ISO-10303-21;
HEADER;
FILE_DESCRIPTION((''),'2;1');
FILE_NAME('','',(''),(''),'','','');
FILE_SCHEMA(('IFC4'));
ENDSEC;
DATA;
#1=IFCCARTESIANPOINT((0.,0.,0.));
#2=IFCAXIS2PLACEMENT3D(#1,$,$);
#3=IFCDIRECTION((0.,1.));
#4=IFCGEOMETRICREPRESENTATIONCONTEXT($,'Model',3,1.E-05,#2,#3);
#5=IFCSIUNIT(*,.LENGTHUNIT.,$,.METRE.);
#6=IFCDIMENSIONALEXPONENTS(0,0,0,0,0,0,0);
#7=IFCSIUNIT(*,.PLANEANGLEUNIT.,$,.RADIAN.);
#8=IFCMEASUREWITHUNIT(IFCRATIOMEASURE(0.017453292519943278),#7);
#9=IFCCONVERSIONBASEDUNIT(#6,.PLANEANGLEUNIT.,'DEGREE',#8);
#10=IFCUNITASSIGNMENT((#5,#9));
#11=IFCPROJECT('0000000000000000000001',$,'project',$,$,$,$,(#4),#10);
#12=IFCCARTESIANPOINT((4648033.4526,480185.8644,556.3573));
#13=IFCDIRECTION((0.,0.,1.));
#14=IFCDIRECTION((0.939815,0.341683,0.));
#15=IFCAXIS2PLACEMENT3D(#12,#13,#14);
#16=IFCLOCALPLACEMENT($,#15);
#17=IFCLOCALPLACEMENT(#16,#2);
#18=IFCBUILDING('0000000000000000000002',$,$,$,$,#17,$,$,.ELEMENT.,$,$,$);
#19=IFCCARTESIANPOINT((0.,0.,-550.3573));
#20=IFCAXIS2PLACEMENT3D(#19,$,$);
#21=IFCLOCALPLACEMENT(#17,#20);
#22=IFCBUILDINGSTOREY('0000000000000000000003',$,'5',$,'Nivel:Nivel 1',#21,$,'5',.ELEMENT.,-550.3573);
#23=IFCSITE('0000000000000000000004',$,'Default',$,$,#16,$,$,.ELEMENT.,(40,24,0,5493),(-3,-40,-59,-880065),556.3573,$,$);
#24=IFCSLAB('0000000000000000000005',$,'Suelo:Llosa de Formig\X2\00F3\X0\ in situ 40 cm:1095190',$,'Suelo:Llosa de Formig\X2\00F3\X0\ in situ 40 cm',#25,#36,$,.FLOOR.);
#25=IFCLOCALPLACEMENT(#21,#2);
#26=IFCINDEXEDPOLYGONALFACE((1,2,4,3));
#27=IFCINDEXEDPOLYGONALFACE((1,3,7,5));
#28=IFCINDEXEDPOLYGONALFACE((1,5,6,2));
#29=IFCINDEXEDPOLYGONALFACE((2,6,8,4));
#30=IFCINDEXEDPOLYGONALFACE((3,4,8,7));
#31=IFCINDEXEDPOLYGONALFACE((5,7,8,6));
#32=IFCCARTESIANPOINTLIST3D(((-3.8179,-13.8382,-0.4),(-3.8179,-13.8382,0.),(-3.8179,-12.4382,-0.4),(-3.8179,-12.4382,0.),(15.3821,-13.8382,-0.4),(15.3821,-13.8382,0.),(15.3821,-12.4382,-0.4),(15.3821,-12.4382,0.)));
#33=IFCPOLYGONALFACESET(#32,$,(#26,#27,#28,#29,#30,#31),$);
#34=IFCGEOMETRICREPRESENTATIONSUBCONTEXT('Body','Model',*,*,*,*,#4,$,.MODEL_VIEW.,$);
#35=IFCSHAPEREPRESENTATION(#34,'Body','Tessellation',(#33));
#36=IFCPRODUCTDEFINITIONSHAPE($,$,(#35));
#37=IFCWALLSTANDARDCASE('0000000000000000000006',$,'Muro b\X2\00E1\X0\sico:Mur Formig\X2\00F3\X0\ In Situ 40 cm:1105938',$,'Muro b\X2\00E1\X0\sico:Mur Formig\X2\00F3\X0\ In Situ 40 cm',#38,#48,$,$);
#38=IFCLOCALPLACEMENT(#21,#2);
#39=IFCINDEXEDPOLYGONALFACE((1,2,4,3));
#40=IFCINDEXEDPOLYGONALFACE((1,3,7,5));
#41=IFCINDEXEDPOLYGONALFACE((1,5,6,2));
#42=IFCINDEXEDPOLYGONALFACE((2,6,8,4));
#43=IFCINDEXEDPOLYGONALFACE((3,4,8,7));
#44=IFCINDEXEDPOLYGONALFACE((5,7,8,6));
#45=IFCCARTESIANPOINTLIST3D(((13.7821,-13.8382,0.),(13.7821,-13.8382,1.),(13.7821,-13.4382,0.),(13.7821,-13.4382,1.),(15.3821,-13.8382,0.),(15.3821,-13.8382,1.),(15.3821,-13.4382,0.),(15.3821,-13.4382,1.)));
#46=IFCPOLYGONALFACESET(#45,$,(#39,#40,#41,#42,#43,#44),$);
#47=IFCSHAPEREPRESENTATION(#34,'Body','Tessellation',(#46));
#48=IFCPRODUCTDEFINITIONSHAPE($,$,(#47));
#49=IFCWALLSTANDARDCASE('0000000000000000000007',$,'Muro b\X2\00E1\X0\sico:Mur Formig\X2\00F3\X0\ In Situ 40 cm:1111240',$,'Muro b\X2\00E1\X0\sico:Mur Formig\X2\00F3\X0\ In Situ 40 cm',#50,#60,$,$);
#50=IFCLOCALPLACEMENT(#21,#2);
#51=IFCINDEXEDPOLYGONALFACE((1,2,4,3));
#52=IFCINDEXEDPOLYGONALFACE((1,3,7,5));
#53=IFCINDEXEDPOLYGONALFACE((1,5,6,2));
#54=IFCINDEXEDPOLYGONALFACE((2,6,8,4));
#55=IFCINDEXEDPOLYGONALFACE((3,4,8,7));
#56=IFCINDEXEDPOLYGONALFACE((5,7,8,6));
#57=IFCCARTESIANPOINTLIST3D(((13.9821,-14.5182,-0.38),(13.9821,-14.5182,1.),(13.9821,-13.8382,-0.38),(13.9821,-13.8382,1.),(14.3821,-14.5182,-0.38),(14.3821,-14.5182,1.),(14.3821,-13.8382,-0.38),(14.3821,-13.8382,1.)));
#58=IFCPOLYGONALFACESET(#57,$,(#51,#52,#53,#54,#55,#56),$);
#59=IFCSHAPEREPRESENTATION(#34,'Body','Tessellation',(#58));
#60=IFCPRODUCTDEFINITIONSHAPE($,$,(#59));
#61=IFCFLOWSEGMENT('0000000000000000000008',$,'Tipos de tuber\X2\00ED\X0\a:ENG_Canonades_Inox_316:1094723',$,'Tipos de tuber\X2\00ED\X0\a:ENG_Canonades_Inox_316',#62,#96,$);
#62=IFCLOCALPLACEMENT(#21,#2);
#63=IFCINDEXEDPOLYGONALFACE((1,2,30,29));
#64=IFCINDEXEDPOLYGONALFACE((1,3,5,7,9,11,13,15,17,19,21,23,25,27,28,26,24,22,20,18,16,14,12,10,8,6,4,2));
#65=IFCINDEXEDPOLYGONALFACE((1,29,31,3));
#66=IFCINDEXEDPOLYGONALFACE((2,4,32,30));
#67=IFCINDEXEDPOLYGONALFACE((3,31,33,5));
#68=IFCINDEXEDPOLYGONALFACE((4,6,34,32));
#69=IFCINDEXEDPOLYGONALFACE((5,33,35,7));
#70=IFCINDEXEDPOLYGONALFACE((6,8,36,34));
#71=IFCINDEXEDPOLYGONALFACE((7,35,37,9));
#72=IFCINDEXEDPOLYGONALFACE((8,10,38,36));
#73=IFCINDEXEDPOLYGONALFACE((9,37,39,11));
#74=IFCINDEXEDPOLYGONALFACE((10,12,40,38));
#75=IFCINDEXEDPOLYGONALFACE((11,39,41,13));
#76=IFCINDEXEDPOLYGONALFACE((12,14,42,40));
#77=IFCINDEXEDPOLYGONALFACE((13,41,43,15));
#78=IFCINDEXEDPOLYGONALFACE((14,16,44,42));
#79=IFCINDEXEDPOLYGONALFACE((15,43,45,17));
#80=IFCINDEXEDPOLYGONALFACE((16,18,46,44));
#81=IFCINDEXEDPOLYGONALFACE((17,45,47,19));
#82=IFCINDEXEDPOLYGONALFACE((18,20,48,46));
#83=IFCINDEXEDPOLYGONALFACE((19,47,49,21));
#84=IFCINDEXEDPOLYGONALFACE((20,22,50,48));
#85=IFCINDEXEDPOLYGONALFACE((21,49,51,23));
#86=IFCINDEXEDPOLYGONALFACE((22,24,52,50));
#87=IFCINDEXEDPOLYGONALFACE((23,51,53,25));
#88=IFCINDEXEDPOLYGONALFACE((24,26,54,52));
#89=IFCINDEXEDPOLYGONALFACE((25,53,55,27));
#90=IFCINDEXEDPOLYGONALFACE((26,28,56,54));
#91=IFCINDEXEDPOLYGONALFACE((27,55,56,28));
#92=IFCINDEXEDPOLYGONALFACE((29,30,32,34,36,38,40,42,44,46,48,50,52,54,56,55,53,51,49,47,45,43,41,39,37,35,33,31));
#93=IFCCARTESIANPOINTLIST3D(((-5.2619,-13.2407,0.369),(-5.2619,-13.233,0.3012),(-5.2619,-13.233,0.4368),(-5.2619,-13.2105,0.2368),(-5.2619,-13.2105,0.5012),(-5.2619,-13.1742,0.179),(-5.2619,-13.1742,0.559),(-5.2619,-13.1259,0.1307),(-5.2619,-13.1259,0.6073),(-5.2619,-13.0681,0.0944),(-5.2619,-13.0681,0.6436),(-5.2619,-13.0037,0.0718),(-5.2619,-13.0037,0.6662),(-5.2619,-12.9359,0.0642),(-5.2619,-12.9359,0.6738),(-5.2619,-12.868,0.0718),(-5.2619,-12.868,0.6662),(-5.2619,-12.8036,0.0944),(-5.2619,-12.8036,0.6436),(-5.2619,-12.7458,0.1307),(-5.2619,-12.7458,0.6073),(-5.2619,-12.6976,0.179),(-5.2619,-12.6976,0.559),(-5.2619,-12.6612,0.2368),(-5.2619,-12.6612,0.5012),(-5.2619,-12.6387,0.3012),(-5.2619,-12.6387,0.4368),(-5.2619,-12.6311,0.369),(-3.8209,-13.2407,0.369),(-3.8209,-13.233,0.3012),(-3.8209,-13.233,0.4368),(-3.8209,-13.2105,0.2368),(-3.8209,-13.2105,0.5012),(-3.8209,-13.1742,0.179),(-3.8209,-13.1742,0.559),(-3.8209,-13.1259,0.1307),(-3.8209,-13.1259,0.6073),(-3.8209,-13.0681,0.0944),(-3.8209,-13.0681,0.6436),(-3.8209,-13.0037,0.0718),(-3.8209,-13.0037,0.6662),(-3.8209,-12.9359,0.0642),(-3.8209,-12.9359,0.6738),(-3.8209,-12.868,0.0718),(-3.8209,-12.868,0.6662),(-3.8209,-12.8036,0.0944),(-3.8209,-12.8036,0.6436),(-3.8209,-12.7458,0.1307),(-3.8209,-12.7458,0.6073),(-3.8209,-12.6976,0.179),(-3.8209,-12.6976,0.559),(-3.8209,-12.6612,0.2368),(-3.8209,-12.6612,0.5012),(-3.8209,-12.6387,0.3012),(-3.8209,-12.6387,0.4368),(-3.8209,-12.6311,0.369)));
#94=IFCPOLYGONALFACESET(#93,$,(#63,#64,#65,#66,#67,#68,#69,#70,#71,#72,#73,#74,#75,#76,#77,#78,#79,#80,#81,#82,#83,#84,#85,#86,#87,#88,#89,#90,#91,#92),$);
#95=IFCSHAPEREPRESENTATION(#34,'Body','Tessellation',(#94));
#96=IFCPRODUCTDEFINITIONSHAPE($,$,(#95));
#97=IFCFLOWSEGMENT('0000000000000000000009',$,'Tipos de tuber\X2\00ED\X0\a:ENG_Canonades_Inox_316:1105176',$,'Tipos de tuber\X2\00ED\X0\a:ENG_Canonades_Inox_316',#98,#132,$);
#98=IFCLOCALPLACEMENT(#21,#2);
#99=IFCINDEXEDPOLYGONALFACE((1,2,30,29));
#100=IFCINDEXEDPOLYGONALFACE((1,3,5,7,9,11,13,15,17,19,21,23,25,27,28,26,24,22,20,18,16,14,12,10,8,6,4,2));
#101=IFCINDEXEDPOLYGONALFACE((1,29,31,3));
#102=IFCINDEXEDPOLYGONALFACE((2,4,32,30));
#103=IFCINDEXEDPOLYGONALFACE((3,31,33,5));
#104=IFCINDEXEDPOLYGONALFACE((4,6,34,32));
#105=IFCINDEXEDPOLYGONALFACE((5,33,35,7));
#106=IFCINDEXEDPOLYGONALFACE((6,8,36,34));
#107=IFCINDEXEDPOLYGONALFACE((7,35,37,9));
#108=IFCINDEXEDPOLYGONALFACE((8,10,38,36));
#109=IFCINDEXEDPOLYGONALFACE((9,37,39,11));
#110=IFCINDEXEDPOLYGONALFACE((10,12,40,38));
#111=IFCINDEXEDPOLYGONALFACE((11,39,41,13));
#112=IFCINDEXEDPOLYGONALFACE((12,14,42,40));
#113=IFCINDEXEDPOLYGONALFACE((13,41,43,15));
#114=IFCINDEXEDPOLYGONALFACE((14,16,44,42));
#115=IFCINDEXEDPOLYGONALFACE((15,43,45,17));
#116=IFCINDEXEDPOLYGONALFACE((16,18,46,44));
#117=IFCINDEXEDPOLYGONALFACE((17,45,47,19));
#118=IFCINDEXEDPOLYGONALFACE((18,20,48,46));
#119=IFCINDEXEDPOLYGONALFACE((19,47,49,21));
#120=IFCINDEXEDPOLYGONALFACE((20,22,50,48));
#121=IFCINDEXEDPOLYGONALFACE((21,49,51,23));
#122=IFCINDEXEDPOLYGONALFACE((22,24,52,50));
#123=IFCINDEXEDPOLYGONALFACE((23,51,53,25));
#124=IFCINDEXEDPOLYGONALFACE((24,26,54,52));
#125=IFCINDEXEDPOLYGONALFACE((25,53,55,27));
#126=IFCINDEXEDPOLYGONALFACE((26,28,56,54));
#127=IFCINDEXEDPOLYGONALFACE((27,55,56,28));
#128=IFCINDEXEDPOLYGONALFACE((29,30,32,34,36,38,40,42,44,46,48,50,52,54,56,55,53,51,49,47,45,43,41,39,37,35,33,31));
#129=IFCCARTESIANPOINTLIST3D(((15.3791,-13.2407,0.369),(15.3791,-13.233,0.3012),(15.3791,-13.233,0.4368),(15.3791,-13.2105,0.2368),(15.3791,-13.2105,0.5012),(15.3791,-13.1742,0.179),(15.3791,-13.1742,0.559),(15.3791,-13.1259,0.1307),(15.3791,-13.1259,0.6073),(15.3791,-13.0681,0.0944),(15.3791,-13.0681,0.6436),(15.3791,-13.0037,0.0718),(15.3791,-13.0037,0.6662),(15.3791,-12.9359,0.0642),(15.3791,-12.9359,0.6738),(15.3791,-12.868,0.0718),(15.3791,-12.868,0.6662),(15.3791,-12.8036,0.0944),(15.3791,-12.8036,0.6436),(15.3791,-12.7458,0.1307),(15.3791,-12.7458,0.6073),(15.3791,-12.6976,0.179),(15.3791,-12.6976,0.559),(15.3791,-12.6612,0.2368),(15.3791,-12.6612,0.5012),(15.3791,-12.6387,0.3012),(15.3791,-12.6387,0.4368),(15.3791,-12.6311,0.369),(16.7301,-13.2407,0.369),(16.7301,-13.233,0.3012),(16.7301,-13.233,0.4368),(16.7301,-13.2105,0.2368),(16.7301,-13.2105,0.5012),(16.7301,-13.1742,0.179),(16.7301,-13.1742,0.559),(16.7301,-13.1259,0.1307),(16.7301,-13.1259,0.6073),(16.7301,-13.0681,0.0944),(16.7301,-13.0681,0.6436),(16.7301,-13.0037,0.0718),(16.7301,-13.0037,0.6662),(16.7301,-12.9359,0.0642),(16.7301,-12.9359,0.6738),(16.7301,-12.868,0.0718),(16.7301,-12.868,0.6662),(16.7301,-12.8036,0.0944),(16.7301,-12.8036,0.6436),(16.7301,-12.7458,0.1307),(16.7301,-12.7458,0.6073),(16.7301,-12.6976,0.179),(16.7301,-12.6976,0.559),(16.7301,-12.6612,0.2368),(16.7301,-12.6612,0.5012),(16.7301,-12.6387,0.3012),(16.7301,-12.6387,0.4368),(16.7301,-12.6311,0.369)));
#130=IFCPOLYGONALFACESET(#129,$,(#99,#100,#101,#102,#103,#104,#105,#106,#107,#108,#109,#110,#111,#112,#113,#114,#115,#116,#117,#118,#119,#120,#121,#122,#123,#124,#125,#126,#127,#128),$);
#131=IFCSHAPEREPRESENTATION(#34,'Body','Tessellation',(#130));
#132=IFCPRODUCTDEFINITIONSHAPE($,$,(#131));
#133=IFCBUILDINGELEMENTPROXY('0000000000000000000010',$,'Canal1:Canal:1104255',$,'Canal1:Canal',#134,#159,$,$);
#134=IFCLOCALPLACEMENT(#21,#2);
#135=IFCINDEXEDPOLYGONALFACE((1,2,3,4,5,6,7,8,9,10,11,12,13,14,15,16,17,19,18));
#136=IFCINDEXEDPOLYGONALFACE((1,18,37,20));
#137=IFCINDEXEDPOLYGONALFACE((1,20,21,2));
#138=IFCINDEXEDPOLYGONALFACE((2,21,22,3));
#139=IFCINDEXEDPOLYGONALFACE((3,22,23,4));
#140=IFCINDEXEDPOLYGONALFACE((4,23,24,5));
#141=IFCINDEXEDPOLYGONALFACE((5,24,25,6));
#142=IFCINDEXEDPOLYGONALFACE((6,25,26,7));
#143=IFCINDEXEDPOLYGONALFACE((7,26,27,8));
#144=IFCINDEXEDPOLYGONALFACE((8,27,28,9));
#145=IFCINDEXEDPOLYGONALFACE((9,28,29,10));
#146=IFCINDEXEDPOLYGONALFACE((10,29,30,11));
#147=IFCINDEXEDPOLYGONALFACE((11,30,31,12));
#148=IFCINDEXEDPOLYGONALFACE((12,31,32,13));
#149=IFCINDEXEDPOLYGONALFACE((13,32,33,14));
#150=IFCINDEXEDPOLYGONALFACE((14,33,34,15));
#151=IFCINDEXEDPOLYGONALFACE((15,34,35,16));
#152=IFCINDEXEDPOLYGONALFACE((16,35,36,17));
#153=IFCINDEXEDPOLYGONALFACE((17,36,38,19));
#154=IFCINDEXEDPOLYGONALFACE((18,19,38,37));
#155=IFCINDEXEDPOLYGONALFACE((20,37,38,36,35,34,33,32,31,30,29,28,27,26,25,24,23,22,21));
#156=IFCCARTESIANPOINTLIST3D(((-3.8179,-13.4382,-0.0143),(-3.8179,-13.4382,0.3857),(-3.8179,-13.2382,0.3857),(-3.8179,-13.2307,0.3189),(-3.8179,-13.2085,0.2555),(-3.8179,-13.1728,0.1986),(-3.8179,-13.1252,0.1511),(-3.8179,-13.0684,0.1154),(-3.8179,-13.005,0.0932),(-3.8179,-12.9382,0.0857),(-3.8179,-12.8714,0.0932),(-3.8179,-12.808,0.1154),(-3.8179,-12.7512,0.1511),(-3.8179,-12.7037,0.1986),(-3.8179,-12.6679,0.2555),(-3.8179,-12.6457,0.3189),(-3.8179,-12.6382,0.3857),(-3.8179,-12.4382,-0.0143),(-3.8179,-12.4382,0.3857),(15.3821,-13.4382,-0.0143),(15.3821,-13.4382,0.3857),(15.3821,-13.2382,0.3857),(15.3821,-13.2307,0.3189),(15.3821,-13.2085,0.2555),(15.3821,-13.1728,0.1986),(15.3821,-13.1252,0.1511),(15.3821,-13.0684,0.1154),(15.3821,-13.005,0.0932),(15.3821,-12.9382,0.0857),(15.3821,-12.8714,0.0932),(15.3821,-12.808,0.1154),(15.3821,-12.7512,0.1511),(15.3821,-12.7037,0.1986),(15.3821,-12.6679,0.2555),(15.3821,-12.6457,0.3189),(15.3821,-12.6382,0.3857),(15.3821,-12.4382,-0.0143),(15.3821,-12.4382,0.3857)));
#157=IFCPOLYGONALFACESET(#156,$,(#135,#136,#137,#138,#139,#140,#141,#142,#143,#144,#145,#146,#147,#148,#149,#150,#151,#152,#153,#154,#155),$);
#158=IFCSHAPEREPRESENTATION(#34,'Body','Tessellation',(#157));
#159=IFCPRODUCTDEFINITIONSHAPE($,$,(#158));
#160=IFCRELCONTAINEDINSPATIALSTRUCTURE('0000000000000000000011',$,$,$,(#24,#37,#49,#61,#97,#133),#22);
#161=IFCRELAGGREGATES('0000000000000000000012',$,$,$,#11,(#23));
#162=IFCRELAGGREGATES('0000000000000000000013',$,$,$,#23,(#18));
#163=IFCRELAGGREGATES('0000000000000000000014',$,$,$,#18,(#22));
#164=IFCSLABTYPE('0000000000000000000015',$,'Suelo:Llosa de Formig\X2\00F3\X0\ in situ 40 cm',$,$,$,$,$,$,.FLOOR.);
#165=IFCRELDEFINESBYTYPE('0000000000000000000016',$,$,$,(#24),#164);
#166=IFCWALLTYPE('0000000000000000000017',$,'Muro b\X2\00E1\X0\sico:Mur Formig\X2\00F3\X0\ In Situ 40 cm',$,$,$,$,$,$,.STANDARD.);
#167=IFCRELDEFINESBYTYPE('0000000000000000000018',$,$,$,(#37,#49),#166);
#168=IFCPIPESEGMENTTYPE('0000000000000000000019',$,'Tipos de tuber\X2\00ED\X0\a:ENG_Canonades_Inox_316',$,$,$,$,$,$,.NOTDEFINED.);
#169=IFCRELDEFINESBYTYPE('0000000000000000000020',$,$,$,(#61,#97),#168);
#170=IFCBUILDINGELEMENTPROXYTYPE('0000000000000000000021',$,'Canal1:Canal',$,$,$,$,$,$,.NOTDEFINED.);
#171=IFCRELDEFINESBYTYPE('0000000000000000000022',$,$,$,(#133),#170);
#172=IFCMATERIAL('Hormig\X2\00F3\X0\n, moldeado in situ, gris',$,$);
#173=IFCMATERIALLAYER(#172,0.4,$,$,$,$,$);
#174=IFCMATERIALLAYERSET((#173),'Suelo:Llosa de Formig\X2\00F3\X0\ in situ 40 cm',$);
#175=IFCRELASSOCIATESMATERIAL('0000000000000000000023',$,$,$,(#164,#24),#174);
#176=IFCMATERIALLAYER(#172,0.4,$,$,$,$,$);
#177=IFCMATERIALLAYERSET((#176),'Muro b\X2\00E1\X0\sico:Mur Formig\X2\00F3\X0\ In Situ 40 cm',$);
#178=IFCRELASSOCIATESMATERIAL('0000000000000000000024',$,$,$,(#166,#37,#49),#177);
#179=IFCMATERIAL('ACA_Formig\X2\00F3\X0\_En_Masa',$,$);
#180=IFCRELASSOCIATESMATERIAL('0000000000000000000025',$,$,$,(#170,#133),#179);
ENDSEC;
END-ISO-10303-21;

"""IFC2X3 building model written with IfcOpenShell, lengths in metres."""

from ifc_helpers import new_model, entity, si_unit, converted_unit, direction, frame, frame_2d, origin, origin_2d_with_axis, place, context, subcontext, project, spatial, polyline, circle_curve, parameter, trimmed, segment, composite_curve, rectangle, circle, outline, extrude, source, transform, mapped, material, layer, layer_set, layer_usage, type_object, type_shapes, element, save


model = new_model("IFC2X3")

# Units and contexts
model_context = context("Model", 3, precision=1e-05, world=origin(), true_north=direction((0.0, 1.0)))
body_context = subcontext(model_context, "Body", "Model", "MODEL_VIEW")
ifc_project = project(units=[si_unit("LENGTHUNIT", "METRE"), converted_unit("PLANEANGLEUNIT", "DEGREE", entity("IfcRatioMeasure", 0.017453292519943278), si_unit("PLANEANGLEUNIT", "RADIAN"), dimensions=[0, 0, 0, 0, 0, 0, 0])], contexts=[model_context])

# Site, building, storey
site_placement = place(None, frame((4648033.4526, 480185.8644, 556.3573), z_axis=(0.0, 0.0, 1.0), x_axis=(0.939815, 0.341683, 0.0)))
site = spatial("IfcSite", under=ifc_project, at=site_placement, Name="Default", CompositionType="ELEMENT", RefLatitude=(40, 24, 0, 5493), RefLongitude=(-3, -40, -59, -880065), RefElevation=556.3573)
building_placement = place(site_placement, origin())
building = spatial("IfcBuilding", under=site, at=building_placement, CompositionType="ELEMENT")
storey_placement = place(building_placement, frame((0.0, 0.0, -550.3573)))
storey = spatial("IfcBuildingStorey", under=building, at=storey_placement, Name="5", ObjectType="Nivel:Nivel 1", LongName="5", CompositionType="ELEMENT", Elevation=-550.3573)

# Slab
ifc_material_1 = material(Name="Hormigón, moldeado in situ, gris")
ifc_layer_1 = layer(ifc_material_1, 0.4)
ifc_layer_set_1 = layer_set([ifc_layer_1], Name="Suelo:Llosa de Formigó in situ 40 cm")
ifc_layer_usage_1 = layer_usage(ifc_layer_set_1, "AXIS3", "POSITIVE", 0.0)
slab_type = type_object("IfcSlabType", Name="Suelo:Llosa de Formigó in situ 40 cm", PredefinedType="FLOOR", material=ifc_layer_set_1)
slab_placement = place(storey_placement, origin())
element("IfcSlab", 1, at=slab_placement, inside=storey, type_object=slab_type, material=ifc_layer_usage_1, Name="Suelo:Llosa de Formigó in situ 40 cm:1095190", ObjectType="Suelo:Llosa de Formigó in situ 40 cm", PredefinedType="FLOOR", context=body_context, shape_type="SweptSolid", body=[
    extrude(rectangle(XDim=1.4, YDim=19.2, at=origin_2d_with_axis()), frame((5.7821, -13.1382, 0.0), z_axis=(0.0, 0.0, -1.0), x_axis=(0.0, 1.0, 0.0)), (0.0, 0.0, 1.0), 0.4),
])

# Walls
ifc_layer_2 = layer(ifc_material_1, 0.4)
ifc_layer_set_2 = layer_set([ifc_layer_2], Name="Muro básico:Mur Formigó In Situ 40 cm")
ifc_layer_usage_2 = layer_usage(ifc_layer_set_2, "AXIS2", "NEGATIVE", 0.2)
wall_type = type_object("IfcWallType", Name="Muro básico:Mur Formigó In Situ 40 cm", PredefinedType="STANDARD", material=ifc_layer_set_2)
wall_1_placement = place(storey_placement, frame((15.3821, -13.6382, 0.0), z_axis=(0.0, 0.0, 1.0), x_axis=(-1.0, 0.0, 0.0)))
element("IfcWallStandardCase", 2, at=wall_1_placement, inside=storey, type_object=wall_type, material=ifc_layer_usage_2, Name="Muro básico:Mur Formigó In Situ 40 cm:1105938", ObjectType="Muro básico:Mur Formigó In Situ 40 cm", context=body_context, shape_type="SweptSolid", body=[
    extrude(rectangle(XDim=1.6, YDim=0.4, at=frame_2d((0.8, 0.0), x_axis=(-1.0, 0.0))), origin(), (0.0, 0.0, 1.0), 1.0),
])
ifc_layer_usage_3 = layer_usage(ifc_layer_set_2, "AXIS2", "NEGATIVE", 0.2)
wall_2_placement = place(storey_placement, frame((14.1821, -14.5182, -0.38), z_axis=(0.0, 0.0, 1.0), x_axis=(0.0, 1.0, 0.0)))
element("IfcWallStandardCase", 3, at=wall_2_placement, inside=storey, type_object=wall_type, material=ifc_layer_usage_3, Name="Muro básico:Mur Formigó In Situ 40 cm:1111240", ObjectType="Muro básico:Mur Formigó In Situ 40 cm", context=body_context, shape_type="SweptSolid", body=[
    extrude(rectangle(XDim=0.68, YDim=0.4, at=frame_2d((0.34, 0.0), x_axis=(-1.0, 0.0))), origin(), (0.0, 0.0, 1.0), 1.38),
])

# Flow segments
pipe_segment_type = type_object("IfcPipeSegmentType", Name="Tipos de tubería:ENG_Canonades_Inox_316", PredefinedType="NOTDEFINED")
flow_segment_1_placement = place(storey_placement, origin())
element("IfcFlowSegment", 4, at=flow_segment_1_placement, inside=storey, type_object=pipe_segment_type, Name="Tipos de tubería:ENG_Canonades_Inox_316:1094723", ObjectType="Tipos de tubería:ENG_Canonades_Inox_316", context=body_context, shape_type="SweptSolid", body=[
    extrude(circle(Radius=0.3048, at=frame_2d((0.0, 0.0), x_axis=(1.0, 0.0))), frame((-5.2619, -12.9359, 0.369), z_axis=(1.0, 0.0, 0.0), x_axis=(0.0, -1.0, 0.0)), (0.0, 0.0, 1.0), 1.441),
])
flow_segment_2_placement = place(storey_placement, origin())
element("IfcFlowSegment", 5, at=flow_segment_2_placement, inside=storey, type_object=pipe_segment_type, Name="Tipos de tubería:ENG_Canonades_Inox_316:1105176", ObjectType="Tipos de tubería:ENG_Canonades_Inox_316", context=body_context, shape_type="SweptSolid", body=[
    extrude(circle(Radius=0.3048, at=origin_2d_with_axis()), frame((15.3791, -12.9359, 0.369), z_axis=(1.0, 0.0, 0.0), x_axis=(0.0, -1.0, 0.0)), (0.0, 0.0, 1.0), 1.351),
])

# Building element proxy
ifc_material_2 = material(Name="ACA_Formigó_En_Masa")
building_element_proxy_type = type_object("IfcBuildingElementProxyType", Name="Canal1:Canal", PredefinedType="NOTDEFINED", material=ifc_material_2)
shared_shape = source(origin(), body_context, "Body", "SweptSolid", [
    extrude(outline(composite_curve([segment(polyline([(-0.5, -0.2667), (0.5, -0.2667)]), True, "CONTINUOUS"), segment(polyline([(0.5, -0.2667), (0.5, 0.1333)]), True, "CONTINUOUS"), segment(polyline([(0.5, 0.1333), (0.3, 0.1333)]), True, "CONTINUOUS"), segment(trimmed(circle_curve(frame_2d((0.0, 0.1333), x_axis=(1.0, 0.0)), 0.3), [parameter(180.0)], [parameter(0.0)], True, "PARAMETER"), False, "CONTINUOUS"), segment(polyline([(-0.3, 0.1333), (-0.5, 0.1333)]), True, "CONTINUOUS"), segment(polyline([(-0.5, 0.1333), (-0.5, -0.2667)]), True, "CONTINUOUS")], self_intersect=False)), frame((-3.8179, -12.9382, -549.8397), z_axis=(1.0, 0.0, 0.0), x_axis=(0.0, 1.0, 0.0)), (0.0, 0.0, 1.0), 19.2),
])
type_shapes(building_element_proxy_type, [shared_shape])
proxy_placement = place(storey_placement, frame((0.0, 0.0, 550.092)))
element("IfcBuildingElementProxy", 6, at=proxy_placement, inside=storey, type_object=building_element_proxy_type, material=ifc_material_2, Name="Canal1:Canal:1104255", ObjectType="Canal1:Canal", context=body_context, shape_type="MappedRepresentation", body=[
    mapped(shared_shape, transform((0.0, 0.0, 0.0), scale=1.0)),
])

save(model, "model.ifc")
